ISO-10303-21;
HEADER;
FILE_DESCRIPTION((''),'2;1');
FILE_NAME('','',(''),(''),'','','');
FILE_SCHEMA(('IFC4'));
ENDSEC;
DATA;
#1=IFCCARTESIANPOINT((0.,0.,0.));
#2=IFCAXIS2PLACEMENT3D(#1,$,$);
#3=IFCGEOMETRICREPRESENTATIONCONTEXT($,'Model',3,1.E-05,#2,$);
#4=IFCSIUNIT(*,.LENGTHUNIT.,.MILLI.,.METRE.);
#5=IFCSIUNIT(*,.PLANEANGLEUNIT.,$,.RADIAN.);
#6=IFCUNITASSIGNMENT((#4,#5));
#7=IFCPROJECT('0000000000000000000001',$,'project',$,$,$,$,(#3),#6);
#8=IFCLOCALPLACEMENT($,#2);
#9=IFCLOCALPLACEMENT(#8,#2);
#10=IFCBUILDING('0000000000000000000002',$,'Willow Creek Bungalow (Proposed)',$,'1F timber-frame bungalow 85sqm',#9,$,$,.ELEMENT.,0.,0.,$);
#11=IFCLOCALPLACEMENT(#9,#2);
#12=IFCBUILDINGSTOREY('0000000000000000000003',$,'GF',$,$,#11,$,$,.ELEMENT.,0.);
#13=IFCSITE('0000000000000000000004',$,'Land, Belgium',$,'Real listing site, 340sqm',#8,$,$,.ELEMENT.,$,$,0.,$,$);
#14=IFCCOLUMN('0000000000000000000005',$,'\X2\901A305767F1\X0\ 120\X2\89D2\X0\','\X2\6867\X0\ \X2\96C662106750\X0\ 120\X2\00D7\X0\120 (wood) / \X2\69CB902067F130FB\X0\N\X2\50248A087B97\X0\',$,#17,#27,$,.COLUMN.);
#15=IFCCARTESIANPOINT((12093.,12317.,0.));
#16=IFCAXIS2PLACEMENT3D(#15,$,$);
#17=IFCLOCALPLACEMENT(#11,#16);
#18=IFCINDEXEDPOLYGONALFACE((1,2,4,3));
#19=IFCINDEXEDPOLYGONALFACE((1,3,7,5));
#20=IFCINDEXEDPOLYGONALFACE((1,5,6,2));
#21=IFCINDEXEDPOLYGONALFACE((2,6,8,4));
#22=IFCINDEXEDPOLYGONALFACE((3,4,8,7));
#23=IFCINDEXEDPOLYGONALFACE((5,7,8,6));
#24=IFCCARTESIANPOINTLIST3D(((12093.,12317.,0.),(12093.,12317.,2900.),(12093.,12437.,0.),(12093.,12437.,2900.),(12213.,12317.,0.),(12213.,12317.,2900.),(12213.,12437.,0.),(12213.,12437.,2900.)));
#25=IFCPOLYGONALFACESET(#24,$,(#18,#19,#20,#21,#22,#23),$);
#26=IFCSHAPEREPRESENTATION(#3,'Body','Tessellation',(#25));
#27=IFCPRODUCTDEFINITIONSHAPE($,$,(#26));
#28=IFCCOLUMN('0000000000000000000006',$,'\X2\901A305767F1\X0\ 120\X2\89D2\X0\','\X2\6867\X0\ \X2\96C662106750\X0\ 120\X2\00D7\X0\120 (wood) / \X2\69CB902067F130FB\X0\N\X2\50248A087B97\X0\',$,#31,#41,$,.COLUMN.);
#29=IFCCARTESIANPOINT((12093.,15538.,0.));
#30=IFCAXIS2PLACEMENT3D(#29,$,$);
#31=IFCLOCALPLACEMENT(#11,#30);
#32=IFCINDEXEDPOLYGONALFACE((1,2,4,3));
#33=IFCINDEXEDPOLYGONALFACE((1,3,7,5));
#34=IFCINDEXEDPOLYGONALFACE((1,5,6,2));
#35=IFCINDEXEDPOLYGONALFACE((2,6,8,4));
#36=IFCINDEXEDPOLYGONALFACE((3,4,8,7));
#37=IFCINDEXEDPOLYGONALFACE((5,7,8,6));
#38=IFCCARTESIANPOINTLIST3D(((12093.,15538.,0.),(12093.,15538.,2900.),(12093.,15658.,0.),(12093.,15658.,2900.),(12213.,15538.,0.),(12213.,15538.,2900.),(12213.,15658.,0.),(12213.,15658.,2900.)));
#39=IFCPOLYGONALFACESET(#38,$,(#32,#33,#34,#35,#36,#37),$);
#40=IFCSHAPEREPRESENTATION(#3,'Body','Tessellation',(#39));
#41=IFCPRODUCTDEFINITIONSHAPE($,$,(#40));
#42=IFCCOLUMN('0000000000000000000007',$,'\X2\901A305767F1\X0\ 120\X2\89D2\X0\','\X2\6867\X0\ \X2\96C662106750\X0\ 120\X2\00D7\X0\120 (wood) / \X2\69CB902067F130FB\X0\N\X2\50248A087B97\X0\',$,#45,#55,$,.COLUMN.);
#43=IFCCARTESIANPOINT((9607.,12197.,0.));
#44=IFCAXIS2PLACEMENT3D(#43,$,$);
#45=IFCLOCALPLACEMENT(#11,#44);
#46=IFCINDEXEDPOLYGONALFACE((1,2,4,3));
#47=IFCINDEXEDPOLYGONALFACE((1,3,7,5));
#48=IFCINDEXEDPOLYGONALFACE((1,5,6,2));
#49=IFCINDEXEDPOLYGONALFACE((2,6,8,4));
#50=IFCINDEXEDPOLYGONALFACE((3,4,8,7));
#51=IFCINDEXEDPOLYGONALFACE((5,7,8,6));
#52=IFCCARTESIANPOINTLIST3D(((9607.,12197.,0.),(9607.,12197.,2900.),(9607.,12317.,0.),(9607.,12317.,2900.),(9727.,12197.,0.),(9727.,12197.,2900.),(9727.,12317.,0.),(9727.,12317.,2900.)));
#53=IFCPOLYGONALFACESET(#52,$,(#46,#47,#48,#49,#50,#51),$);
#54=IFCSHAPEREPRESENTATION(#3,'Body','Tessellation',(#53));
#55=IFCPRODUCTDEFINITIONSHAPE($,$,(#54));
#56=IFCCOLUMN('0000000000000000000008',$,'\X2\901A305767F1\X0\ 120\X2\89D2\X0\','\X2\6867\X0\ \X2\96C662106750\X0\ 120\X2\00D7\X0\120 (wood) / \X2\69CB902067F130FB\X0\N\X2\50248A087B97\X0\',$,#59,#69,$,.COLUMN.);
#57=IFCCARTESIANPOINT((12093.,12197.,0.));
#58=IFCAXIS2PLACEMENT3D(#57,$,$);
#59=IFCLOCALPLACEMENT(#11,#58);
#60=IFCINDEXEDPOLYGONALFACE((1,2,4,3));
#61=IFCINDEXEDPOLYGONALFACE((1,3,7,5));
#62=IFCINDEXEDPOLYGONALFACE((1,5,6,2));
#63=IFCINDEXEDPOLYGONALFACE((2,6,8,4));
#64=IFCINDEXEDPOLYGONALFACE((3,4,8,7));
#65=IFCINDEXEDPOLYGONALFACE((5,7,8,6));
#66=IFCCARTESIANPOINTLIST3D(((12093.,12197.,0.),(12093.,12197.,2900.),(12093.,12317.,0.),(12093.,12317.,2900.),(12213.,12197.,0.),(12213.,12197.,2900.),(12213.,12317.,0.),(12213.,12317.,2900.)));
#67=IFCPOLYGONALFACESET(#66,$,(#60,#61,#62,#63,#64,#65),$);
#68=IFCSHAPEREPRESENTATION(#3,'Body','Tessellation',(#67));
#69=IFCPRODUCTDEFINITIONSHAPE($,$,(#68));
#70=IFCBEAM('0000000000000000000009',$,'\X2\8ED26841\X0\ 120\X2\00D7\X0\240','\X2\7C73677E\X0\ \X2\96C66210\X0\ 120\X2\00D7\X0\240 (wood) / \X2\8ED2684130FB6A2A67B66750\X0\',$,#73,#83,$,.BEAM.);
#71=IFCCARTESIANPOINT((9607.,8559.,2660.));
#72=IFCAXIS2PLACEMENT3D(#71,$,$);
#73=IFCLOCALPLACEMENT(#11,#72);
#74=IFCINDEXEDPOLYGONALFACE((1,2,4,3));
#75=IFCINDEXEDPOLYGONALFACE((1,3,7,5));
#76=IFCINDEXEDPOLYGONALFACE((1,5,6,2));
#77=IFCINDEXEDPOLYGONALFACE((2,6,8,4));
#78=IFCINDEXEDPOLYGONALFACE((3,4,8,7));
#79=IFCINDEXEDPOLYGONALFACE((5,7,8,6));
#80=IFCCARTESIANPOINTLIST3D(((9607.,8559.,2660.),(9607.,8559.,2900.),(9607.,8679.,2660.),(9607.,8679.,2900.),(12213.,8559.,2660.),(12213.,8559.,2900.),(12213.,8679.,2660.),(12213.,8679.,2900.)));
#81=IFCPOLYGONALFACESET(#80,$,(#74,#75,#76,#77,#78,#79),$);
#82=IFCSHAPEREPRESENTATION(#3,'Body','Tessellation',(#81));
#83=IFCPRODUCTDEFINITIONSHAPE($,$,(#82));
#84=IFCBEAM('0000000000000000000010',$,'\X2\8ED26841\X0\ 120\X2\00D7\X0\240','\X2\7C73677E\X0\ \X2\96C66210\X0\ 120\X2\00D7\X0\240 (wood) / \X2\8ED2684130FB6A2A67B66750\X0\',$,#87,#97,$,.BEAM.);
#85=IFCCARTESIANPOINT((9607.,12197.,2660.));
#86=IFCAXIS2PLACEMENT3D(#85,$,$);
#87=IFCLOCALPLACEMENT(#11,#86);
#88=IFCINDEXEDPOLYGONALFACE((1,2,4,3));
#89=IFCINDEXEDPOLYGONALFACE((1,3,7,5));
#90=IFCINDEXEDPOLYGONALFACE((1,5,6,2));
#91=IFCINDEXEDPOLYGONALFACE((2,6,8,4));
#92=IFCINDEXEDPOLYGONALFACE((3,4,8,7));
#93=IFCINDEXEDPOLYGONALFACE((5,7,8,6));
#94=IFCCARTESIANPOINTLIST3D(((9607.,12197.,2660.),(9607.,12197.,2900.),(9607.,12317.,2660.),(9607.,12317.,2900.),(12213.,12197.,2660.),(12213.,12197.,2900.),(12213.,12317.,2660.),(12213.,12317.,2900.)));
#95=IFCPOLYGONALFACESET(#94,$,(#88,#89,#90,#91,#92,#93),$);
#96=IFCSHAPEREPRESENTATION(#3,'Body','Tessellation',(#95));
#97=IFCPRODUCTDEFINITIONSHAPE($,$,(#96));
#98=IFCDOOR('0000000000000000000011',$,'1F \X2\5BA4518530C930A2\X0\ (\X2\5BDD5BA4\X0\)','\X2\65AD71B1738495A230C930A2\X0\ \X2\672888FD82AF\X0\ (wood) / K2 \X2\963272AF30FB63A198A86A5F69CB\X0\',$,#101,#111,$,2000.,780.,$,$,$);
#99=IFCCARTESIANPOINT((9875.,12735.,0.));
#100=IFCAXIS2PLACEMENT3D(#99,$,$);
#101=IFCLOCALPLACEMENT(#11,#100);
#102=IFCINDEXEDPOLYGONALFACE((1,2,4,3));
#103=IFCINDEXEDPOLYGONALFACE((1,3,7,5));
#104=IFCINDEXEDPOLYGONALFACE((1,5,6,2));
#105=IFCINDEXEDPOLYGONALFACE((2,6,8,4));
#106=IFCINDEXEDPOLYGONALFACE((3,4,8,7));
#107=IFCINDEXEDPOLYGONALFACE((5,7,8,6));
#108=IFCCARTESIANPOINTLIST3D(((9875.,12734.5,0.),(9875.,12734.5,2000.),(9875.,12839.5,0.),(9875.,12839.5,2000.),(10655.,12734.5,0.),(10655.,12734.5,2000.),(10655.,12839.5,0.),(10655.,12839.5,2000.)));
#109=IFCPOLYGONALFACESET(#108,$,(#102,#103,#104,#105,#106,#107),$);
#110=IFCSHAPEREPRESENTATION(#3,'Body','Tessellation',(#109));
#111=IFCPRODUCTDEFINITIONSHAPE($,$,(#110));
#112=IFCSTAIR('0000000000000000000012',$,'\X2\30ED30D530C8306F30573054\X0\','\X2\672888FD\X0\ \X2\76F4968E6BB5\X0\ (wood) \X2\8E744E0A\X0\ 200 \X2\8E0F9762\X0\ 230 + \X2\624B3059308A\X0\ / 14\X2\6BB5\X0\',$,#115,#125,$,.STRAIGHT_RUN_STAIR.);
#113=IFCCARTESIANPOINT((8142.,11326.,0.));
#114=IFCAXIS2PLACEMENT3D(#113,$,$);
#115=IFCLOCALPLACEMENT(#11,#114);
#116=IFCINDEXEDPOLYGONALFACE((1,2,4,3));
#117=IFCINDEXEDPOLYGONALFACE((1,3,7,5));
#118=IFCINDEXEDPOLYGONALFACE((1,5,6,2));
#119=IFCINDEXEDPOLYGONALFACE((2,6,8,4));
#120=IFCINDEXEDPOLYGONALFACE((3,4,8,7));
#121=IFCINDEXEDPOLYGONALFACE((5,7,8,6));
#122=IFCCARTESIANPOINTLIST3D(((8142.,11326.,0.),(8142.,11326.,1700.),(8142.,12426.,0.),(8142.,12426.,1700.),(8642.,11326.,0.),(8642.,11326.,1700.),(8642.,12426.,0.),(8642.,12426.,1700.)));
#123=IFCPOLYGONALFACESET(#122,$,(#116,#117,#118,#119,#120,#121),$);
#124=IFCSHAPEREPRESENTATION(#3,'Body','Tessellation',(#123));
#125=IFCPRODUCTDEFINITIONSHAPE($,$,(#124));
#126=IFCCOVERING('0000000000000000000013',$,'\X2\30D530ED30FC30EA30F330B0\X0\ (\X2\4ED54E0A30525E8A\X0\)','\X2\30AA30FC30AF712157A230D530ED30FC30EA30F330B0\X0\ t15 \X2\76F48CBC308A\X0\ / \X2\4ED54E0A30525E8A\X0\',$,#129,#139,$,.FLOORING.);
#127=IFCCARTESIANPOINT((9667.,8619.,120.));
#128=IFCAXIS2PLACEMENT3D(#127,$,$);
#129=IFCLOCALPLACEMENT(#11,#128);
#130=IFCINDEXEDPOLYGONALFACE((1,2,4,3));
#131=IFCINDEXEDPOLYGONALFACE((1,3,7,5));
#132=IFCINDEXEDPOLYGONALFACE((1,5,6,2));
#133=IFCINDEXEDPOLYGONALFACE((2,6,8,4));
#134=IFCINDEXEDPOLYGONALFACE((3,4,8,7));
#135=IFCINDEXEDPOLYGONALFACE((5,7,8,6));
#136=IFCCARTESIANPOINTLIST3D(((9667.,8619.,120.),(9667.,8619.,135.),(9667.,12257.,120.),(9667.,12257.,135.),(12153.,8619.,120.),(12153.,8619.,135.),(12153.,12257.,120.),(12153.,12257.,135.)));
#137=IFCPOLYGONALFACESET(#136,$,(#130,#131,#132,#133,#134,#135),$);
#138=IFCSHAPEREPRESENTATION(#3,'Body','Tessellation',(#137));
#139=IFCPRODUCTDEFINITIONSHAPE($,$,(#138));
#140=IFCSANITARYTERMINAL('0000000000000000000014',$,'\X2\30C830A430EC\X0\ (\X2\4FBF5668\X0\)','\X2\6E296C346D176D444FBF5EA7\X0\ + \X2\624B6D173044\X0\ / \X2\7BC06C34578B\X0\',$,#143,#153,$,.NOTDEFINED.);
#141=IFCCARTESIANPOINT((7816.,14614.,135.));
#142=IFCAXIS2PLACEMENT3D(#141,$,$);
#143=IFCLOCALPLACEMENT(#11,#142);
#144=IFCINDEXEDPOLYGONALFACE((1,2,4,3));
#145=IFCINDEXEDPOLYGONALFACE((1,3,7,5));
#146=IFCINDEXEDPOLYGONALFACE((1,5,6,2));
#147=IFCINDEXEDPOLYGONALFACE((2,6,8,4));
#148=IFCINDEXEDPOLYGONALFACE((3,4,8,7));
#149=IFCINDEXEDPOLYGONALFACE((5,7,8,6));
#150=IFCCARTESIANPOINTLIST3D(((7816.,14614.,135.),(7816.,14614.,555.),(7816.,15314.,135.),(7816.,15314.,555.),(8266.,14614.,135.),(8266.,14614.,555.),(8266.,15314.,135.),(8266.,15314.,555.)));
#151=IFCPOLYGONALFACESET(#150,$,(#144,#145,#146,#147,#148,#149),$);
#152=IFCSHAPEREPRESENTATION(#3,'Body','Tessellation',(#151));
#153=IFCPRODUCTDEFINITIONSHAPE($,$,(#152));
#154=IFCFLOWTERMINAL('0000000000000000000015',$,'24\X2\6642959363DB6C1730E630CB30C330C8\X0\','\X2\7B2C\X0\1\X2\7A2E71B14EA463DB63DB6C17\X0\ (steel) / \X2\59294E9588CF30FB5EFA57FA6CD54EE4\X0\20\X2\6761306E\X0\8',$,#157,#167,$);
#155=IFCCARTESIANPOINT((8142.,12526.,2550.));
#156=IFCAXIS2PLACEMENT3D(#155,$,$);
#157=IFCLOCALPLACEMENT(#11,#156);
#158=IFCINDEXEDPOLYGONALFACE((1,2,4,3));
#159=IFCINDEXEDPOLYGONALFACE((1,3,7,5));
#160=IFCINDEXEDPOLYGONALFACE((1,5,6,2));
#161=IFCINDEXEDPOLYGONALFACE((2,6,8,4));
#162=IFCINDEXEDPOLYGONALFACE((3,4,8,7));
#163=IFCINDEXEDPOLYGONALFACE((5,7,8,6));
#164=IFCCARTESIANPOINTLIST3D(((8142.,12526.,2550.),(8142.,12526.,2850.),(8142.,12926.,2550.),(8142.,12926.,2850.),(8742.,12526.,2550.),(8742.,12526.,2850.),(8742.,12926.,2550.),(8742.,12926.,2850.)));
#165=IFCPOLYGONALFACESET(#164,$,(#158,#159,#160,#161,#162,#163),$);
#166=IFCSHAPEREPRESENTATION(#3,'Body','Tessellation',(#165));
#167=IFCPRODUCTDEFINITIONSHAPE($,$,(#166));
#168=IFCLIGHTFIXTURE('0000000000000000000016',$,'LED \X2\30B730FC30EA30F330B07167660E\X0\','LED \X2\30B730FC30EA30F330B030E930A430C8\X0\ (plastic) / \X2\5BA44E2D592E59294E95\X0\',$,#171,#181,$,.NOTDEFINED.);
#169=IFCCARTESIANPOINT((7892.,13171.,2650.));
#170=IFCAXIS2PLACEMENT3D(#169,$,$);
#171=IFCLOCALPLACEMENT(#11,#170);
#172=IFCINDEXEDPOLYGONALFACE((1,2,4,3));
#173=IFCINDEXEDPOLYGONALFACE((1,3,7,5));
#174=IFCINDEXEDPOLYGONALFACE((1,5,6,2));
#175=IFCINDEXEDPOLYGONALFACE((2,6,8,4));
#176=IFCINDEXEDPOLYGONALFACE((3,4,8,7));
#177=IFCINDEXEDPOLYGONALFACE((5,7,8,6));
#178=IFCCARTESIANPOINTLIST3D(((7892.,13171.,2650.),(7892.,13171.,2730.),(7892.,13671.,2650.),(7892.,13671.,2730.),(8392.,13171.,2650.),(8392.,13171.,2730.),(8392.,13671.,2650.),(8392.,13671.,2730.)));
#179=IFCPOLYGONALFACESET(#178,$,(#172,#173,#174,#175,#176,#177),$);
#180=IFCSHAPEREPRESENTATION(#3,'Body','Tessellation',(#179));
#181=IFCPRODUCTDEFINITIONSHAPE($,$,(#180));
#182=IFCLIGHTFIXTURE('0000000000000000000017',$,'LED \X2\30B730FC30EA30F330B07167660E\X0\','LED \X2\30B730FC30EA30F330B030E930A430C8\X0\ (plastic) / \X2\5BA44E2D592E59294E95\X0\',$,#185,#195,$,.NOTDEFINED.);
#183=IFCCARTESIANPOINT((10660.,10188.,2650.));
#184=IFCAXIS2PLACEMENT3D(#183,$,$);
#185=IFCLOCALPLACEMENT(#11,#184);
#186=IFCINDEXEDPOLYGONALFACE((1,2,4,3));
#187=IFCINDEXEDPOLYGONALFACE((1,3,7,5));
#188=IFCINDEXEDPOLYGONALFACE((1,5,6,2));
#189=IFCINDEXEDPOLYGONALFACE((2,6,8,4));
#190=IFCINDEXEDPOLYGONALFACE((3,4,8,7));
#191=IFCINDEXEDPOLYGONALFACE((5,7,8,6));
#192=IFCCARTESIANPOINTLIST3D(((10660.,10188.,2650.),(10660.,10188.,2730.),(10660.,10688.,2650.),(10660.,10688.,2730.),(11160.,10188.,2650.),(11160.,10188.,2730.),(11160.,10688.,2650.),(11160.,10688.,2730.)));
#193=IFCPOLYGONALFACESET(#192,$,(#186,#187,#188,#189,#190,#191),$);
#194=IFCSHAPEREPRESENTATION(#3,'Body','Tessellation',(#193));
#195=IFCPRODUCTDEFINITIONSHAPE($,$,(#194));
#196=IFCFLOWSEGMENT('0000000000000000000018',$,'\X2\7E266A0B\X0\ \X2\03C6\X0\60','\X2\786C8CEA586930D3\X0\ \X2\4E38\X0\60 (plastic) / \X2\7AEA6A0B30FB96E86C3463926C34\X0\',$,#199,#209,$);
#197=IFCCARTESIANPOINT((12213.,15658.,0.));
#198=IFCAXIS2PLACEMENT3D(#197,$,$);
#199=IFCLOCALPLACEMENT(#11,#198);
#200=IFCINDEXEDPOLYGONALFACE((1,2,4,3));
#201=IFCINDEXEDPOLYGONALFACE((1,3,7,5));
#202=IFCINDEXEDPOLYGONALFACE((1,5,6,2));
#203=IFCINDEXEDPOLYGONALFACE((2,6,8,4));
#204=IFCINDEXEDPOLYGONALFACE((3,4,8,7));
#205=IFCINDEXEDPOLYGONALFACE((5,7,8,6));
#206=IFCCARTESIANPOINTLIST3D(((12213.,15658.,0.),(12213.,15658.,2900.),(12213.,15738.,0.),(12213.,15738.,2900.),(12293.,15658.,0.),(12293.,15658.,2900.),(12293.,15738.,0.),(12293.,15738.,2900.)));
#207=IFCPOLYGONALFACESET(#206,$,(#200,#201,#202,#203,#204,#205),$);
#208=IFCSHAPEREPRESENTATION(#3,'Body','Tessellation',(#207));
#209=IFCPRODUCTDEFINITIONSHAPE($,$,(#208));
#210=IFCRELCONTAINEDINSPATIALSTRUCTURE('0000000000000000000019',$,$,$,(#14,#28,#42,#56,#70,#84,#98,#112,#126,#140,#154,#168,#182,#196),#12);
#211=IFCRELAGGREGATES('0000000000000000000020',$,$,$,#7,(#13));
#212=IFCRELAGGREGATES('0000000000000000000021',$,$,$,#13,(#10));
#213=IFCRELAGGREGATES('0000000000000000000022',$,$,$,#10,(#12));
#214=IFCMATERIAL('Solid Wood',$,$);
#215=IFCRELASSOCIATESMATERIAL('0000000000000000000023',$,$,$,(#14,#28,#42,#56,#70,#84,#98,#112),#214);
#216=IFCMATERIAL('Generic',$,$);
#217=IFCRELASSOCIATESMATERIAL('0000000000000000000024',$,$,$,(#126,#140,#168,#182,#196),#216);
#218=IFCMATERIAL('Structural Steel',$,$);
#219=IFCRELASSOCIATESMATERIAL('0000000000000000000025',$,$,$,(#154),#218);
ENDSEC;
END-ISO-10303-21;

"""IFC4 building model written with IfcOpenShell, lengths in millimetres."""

from ifc_helpers import new_model, si_unit, frame, frame_2d, origin, place, context, project, spatial, rectangle, extrude, material, element, save


model = new_model("IFC4")

# Units and contexts
model_context = context("Model", 3, precision=1e-05, world=origin())
ifc_project = project(units=[si_unit("LENGTHUNIT", "METRE", prefix="MILLI"), si_unit("PLANEANGLEUNIT", "RADIAN")], contexts=[model_context])

# Site, building, storey
site_placement = place(None, origin())
site = spatial("IfcSite", under=ifc_project, at=site_placement, Name="Land, Belgium", ObjectType="Real listing site, 340sqm", CompositionType="ELEMENT", RefElevation=0.0)
building_placement = place(site_placement, origin())
building = spatial("IfcBuilding", under=site, at=building_placement, Name="Willow Creek Bungalow (Proposed)", ObjectType="1F timber-frame bungalow 85sqm", CompositionType="ELEMENT", ElevationOfRefHeight=0.0, ElevationOfTerrain=0.0)
storey_placement = place(building_placement, origin())
storey = spatial("IfcBuildingStorey", under=building, at=storey_placement, Name="GF", CompositionType="ELEMENT", Elevation=0.0)

# Columns
ifc_material_1 = material(Name="Solid Wood")
column_1_placement = place(storey_placement, frame((12093.0, 12317.0, 0.0)))
element("IfcColumn", 1, at=column_1_placement, inside=storey, material=ifc_material_1, Name="通し柱 120角", Description="桧 集成材 120×120 (wood) / 構造柱・N値計算", PredefinedType="COLUMN", context=model_context, shape_type="SweptSolid", body=[
    extrude(rectangle(XDim=120.0, YDim=120.0, at=frame_2d((60.0, 60.0))), frame((12093.0, 12317.0, 0.0)), (0.0, 0.0, 1.0), 2900.0),
])
column_2_placement = place(storey_placement, frame((12093.0, 15538.0, 0.0)))
element("IfcColumn", 2, at=column_2_placement, inside=storey, material=ifc_material_1, Name="通し柱 120角", Description="桧 集成材 120×120 (wood) / 構造柱・N値計算", PredefinedType="COLUMN", context=model_context, shape_type="SweptSolid", body=[
    extrude(rectangle(XDim=120.0, YDim=120.0, at=frame_2d((60.0, 60.0))), frame((12093.0, 15538.0, 0.0)), (0.0, 0.0, 1.0), 2900.0),
])
column_3_placement = place(storey_placement, frame((9607.0, 12197.0, 0.0)))
element("IfcColumn", 3, at=column_3_placement, inside=storey, material=ifc_material_1, Name="通し柱 120角", Description="桧 集成材 120×120 (wood) / 構造柱・N値計算", PredefinedType="COLUMN", context=model_context, shape_type="SweptSolid", body=[
    extrude(rectangle(XDim=120.0, YDim=120.0, at=frame_2d((60.0, 60.0))), frame((9607.0, 12197.0, 0.0)), (0.0, 0.0, 1.0), 2900.0),
])
column_4_placement = place(storey_placement, frame((12093.0, 12197.0, 0.0)))
element("IfcColumn", 4, at=column_4_placement, inside=storey, material=ifc_material_1, Name="通し柱 120角", Description="桧 集成材 120×120 (wood) / 構造柱・N値計算", PredefinedType="COLUMN", context=model_context, shape_type="SweptSolid", body=[
    extrude(rectangle(XDim=120.0, YDim=120.0, at=frame_2d((60.0, 60.0))), frame((12093.0, 12197.0, 0.0)), (0.0, 0.0, 1.0), 2900.0),
])

# Beams
beam_1_placement = place(storey_placement, frame((9607.0, 8559.0, 2660.0)))
element("IfcBeam", 5, at=beam_1_placement, inside=storey, material=ifc_material_1, Name="軒桁 120×240", Description="米松 集成 120×240 (wood) / 軒桁・横架材", PredefinedType="BEAM", context=model_context, shape_type="SweptSolid", body=[
    extrude(rectangle(XDim=2606.0, YDim=120.0, at=frame_2d((1303.0, 60.0))), frame((9607.0, 8559.0, 2660.0)), (0.0, 0.0, 1.0), 240.0),
])
beam_2_placement = place(storey_placement, frame((9607.0, 12197.0, 2660.0)))
element("IfcBeam", 6, at=beam_2_placement, inside=storey, material=ifc_material_1, Name="軒桁 120×240", Description="米松 集成 120×240 (wood) / 軒桁・横架材", PredefinedType="BEAM", context=model_context, shape_type="SweptSolid", body=[
    extrude(rectangle(XDim=2606.0, YDim=120.0, at=frame_2d((1303.0, 60.0))), frame((9607.0, 12197.0, 2660.0)), (0.0, 0.0, 1.0), 240.0),
])

# Door
door_placement = place(storey_placement, frame((9875.0, 12735.0, 0.0)))
element("IfcDoor", 7, at=door_placement, inside=storey, material=ifc_material_1, Name="1F 室内ドア (寝室)", Description="断熱玄関ドア 木製芯 (wood) / K2 防犯・採風機構", OverallHeight=2000.0, OverallWidth=780.0, context=model_context, shape_type="SweptSolid", body=[
    extrude(rectangle(XDim=780.0, YDim=105.0, at=frame_2d((390.0, 52.0))), frame((9875.0, 12735.0, 0.0)), (0.0, 0.0, 1.0), 2000.0),
])

# Stair
stair_placement = place(storey_placement, frame((8142.0, 11326.0, 0.0)))
element("IfcStair", 8, at=stair_placement, inside=storey, material=ifc_material_1, Name="ロフトはしご", Description="木製 直階段 (wood) 蹴上 200 踏面 230 + 手すり / 14段", PredefinedType="STRAIGHT_RUN_STAIR", context=model_context, shape_type="SweptSolid", body=[
    extrude(rectangle(XDim=500.0, YDim=1100.0, at=frame_2d((250.0, 550.0))), frame((8142.0, 11326.0, 0.0)), (0.0, 0.0, 1.0), 1700.0),
])

# Covering
ifc_material_2 = material(Name="Generic")
covering_placement = place(storey_placement, frame((9667.0, 8619.0, 120.0)))
element("IfcCovering", 9, at=covering_placement, inside=storey, material=ifc_material_2, Name="フローリング (仕上げ床)", Description="オーク無垢フローリング t15 直貼り / 仕上げ床", PredefinedType="FLOORING", context=model_context, shape_type="SweptSolid", body=[
    extrude(rectangle(XDim=2486.0, YDim=3638.0, at=frame_2d((1243.0, 1819.0))), frame((9667.0, 8619.0, 120.0)), (0.0, 0.0, 1.0), 15.0),
])

# Sanitary terminal
sanitary_terminal_placement = place(storey_placement, frame((7816.0, 14614.0, 135.0)))
element("IfcSanitaryTerminal", 10, at=sanitary_terminal_placement, inside=storey, material=ifc_material_2, Name="トイレ (便器)", Description="温水洗浄便座 + 手洗い / 節水型", PredefinedType="NOTDEFINED", context=model_context, shape_type="SweptSolid", body=[
    extrude(rectangle(XDim=450.0, YDim=700.0, at=frame_2d((225.0, 350.0))), frame((7816.0, 14614.0, 135.0)), (0.0, 0.0, 1.0), 420.0),
])

# Flow terminal
ifc_material_3 = material(Name="Structural Steel")
flow_terminal_placement = place(storey_placement, frame((8142.0, 12526.0, 2550.0)))
element("IfcFlowTerminal", 11, at=flow_terminal_placement, inside=storey, material=ifc_material_3, Name="24時間換気ユニット", Description="第1種熱交換換気 (steel) / 天井裏・建基法令20条の8", context=model_context, shape_type="SweptSolid", body=[
    extrude(rectangle(XDim=600.0, YDim=400.0, at=frame_2d((300.0, 200.0))), frame((8142.0, 12526.0, 2550.0)), (0.0, 0.0, 1.0), 300.0),
])

# Light fixtures
light_fixture_1_placement = place(storey_placement, frame((7892.0, 13171.0, 2650.0)))
element("IfcLightFixture", 12, at=light_fixture_1_placement, inside=storey, material=ifc_material_2, Name="LED シーリング照明", Description="LED シーリングライト (plastic) / 室中央天井", PredefinedType="NOTDEFINED", context=model_context, shape_type="SweptSolid", body=[
    extrude(rectangle(XDim=500.0, YDim=500.0, at=frame_2d((250.0, 250.0))), frame((7892.0, 13171.0, 2650.0)), (0.0, 0.0, 1.0), 80.0),
])
light_fixture_2_placement = place(storey_placement, frame((10660.0, 10188.0, 2650.0)))
element("IfcLightFixture", 13, at=light_fixture_2_placement, inside=storey, material=ifc_material_2, Name="LED シーリング照明", Description="LED シーリングライト (plastic) / 室中央天井", PredefinedType="NOTDEFINED", context=model_context, shape_type="SweptSolid", body=[
    extrude(rectangle(XDim=500.0, YDim=500.0, at=frame_2d((250.0, 250.0))), frame((10660.0, 10188.0, 2650.0)), (0.0, 0.0, 1.0), 80.0),
])

# Flow segment
flow_segment_placement = place(storey_placement, frame((12213.0, 15658.0, 0.0)))
element("IfcFlowSegment", 14, at=flow_segment_placement, inside=storey, material=ifc_material_2, Name="縦樋 φ60", Description="硬質塩ビ 丸60 (plastic) / 竪樋・雨水排水", context=model_context, shape_type="SweptSolid", body=[
    extrude(rectangle(XDim=80.0, YDim=80.0, at=frame_2d((40.0, 40.0))), frame((12213.0, 15658.0, 0.0)), (0.0, 0.0, 1.0), 2900.0),
])

save(model, "model.ifc")
